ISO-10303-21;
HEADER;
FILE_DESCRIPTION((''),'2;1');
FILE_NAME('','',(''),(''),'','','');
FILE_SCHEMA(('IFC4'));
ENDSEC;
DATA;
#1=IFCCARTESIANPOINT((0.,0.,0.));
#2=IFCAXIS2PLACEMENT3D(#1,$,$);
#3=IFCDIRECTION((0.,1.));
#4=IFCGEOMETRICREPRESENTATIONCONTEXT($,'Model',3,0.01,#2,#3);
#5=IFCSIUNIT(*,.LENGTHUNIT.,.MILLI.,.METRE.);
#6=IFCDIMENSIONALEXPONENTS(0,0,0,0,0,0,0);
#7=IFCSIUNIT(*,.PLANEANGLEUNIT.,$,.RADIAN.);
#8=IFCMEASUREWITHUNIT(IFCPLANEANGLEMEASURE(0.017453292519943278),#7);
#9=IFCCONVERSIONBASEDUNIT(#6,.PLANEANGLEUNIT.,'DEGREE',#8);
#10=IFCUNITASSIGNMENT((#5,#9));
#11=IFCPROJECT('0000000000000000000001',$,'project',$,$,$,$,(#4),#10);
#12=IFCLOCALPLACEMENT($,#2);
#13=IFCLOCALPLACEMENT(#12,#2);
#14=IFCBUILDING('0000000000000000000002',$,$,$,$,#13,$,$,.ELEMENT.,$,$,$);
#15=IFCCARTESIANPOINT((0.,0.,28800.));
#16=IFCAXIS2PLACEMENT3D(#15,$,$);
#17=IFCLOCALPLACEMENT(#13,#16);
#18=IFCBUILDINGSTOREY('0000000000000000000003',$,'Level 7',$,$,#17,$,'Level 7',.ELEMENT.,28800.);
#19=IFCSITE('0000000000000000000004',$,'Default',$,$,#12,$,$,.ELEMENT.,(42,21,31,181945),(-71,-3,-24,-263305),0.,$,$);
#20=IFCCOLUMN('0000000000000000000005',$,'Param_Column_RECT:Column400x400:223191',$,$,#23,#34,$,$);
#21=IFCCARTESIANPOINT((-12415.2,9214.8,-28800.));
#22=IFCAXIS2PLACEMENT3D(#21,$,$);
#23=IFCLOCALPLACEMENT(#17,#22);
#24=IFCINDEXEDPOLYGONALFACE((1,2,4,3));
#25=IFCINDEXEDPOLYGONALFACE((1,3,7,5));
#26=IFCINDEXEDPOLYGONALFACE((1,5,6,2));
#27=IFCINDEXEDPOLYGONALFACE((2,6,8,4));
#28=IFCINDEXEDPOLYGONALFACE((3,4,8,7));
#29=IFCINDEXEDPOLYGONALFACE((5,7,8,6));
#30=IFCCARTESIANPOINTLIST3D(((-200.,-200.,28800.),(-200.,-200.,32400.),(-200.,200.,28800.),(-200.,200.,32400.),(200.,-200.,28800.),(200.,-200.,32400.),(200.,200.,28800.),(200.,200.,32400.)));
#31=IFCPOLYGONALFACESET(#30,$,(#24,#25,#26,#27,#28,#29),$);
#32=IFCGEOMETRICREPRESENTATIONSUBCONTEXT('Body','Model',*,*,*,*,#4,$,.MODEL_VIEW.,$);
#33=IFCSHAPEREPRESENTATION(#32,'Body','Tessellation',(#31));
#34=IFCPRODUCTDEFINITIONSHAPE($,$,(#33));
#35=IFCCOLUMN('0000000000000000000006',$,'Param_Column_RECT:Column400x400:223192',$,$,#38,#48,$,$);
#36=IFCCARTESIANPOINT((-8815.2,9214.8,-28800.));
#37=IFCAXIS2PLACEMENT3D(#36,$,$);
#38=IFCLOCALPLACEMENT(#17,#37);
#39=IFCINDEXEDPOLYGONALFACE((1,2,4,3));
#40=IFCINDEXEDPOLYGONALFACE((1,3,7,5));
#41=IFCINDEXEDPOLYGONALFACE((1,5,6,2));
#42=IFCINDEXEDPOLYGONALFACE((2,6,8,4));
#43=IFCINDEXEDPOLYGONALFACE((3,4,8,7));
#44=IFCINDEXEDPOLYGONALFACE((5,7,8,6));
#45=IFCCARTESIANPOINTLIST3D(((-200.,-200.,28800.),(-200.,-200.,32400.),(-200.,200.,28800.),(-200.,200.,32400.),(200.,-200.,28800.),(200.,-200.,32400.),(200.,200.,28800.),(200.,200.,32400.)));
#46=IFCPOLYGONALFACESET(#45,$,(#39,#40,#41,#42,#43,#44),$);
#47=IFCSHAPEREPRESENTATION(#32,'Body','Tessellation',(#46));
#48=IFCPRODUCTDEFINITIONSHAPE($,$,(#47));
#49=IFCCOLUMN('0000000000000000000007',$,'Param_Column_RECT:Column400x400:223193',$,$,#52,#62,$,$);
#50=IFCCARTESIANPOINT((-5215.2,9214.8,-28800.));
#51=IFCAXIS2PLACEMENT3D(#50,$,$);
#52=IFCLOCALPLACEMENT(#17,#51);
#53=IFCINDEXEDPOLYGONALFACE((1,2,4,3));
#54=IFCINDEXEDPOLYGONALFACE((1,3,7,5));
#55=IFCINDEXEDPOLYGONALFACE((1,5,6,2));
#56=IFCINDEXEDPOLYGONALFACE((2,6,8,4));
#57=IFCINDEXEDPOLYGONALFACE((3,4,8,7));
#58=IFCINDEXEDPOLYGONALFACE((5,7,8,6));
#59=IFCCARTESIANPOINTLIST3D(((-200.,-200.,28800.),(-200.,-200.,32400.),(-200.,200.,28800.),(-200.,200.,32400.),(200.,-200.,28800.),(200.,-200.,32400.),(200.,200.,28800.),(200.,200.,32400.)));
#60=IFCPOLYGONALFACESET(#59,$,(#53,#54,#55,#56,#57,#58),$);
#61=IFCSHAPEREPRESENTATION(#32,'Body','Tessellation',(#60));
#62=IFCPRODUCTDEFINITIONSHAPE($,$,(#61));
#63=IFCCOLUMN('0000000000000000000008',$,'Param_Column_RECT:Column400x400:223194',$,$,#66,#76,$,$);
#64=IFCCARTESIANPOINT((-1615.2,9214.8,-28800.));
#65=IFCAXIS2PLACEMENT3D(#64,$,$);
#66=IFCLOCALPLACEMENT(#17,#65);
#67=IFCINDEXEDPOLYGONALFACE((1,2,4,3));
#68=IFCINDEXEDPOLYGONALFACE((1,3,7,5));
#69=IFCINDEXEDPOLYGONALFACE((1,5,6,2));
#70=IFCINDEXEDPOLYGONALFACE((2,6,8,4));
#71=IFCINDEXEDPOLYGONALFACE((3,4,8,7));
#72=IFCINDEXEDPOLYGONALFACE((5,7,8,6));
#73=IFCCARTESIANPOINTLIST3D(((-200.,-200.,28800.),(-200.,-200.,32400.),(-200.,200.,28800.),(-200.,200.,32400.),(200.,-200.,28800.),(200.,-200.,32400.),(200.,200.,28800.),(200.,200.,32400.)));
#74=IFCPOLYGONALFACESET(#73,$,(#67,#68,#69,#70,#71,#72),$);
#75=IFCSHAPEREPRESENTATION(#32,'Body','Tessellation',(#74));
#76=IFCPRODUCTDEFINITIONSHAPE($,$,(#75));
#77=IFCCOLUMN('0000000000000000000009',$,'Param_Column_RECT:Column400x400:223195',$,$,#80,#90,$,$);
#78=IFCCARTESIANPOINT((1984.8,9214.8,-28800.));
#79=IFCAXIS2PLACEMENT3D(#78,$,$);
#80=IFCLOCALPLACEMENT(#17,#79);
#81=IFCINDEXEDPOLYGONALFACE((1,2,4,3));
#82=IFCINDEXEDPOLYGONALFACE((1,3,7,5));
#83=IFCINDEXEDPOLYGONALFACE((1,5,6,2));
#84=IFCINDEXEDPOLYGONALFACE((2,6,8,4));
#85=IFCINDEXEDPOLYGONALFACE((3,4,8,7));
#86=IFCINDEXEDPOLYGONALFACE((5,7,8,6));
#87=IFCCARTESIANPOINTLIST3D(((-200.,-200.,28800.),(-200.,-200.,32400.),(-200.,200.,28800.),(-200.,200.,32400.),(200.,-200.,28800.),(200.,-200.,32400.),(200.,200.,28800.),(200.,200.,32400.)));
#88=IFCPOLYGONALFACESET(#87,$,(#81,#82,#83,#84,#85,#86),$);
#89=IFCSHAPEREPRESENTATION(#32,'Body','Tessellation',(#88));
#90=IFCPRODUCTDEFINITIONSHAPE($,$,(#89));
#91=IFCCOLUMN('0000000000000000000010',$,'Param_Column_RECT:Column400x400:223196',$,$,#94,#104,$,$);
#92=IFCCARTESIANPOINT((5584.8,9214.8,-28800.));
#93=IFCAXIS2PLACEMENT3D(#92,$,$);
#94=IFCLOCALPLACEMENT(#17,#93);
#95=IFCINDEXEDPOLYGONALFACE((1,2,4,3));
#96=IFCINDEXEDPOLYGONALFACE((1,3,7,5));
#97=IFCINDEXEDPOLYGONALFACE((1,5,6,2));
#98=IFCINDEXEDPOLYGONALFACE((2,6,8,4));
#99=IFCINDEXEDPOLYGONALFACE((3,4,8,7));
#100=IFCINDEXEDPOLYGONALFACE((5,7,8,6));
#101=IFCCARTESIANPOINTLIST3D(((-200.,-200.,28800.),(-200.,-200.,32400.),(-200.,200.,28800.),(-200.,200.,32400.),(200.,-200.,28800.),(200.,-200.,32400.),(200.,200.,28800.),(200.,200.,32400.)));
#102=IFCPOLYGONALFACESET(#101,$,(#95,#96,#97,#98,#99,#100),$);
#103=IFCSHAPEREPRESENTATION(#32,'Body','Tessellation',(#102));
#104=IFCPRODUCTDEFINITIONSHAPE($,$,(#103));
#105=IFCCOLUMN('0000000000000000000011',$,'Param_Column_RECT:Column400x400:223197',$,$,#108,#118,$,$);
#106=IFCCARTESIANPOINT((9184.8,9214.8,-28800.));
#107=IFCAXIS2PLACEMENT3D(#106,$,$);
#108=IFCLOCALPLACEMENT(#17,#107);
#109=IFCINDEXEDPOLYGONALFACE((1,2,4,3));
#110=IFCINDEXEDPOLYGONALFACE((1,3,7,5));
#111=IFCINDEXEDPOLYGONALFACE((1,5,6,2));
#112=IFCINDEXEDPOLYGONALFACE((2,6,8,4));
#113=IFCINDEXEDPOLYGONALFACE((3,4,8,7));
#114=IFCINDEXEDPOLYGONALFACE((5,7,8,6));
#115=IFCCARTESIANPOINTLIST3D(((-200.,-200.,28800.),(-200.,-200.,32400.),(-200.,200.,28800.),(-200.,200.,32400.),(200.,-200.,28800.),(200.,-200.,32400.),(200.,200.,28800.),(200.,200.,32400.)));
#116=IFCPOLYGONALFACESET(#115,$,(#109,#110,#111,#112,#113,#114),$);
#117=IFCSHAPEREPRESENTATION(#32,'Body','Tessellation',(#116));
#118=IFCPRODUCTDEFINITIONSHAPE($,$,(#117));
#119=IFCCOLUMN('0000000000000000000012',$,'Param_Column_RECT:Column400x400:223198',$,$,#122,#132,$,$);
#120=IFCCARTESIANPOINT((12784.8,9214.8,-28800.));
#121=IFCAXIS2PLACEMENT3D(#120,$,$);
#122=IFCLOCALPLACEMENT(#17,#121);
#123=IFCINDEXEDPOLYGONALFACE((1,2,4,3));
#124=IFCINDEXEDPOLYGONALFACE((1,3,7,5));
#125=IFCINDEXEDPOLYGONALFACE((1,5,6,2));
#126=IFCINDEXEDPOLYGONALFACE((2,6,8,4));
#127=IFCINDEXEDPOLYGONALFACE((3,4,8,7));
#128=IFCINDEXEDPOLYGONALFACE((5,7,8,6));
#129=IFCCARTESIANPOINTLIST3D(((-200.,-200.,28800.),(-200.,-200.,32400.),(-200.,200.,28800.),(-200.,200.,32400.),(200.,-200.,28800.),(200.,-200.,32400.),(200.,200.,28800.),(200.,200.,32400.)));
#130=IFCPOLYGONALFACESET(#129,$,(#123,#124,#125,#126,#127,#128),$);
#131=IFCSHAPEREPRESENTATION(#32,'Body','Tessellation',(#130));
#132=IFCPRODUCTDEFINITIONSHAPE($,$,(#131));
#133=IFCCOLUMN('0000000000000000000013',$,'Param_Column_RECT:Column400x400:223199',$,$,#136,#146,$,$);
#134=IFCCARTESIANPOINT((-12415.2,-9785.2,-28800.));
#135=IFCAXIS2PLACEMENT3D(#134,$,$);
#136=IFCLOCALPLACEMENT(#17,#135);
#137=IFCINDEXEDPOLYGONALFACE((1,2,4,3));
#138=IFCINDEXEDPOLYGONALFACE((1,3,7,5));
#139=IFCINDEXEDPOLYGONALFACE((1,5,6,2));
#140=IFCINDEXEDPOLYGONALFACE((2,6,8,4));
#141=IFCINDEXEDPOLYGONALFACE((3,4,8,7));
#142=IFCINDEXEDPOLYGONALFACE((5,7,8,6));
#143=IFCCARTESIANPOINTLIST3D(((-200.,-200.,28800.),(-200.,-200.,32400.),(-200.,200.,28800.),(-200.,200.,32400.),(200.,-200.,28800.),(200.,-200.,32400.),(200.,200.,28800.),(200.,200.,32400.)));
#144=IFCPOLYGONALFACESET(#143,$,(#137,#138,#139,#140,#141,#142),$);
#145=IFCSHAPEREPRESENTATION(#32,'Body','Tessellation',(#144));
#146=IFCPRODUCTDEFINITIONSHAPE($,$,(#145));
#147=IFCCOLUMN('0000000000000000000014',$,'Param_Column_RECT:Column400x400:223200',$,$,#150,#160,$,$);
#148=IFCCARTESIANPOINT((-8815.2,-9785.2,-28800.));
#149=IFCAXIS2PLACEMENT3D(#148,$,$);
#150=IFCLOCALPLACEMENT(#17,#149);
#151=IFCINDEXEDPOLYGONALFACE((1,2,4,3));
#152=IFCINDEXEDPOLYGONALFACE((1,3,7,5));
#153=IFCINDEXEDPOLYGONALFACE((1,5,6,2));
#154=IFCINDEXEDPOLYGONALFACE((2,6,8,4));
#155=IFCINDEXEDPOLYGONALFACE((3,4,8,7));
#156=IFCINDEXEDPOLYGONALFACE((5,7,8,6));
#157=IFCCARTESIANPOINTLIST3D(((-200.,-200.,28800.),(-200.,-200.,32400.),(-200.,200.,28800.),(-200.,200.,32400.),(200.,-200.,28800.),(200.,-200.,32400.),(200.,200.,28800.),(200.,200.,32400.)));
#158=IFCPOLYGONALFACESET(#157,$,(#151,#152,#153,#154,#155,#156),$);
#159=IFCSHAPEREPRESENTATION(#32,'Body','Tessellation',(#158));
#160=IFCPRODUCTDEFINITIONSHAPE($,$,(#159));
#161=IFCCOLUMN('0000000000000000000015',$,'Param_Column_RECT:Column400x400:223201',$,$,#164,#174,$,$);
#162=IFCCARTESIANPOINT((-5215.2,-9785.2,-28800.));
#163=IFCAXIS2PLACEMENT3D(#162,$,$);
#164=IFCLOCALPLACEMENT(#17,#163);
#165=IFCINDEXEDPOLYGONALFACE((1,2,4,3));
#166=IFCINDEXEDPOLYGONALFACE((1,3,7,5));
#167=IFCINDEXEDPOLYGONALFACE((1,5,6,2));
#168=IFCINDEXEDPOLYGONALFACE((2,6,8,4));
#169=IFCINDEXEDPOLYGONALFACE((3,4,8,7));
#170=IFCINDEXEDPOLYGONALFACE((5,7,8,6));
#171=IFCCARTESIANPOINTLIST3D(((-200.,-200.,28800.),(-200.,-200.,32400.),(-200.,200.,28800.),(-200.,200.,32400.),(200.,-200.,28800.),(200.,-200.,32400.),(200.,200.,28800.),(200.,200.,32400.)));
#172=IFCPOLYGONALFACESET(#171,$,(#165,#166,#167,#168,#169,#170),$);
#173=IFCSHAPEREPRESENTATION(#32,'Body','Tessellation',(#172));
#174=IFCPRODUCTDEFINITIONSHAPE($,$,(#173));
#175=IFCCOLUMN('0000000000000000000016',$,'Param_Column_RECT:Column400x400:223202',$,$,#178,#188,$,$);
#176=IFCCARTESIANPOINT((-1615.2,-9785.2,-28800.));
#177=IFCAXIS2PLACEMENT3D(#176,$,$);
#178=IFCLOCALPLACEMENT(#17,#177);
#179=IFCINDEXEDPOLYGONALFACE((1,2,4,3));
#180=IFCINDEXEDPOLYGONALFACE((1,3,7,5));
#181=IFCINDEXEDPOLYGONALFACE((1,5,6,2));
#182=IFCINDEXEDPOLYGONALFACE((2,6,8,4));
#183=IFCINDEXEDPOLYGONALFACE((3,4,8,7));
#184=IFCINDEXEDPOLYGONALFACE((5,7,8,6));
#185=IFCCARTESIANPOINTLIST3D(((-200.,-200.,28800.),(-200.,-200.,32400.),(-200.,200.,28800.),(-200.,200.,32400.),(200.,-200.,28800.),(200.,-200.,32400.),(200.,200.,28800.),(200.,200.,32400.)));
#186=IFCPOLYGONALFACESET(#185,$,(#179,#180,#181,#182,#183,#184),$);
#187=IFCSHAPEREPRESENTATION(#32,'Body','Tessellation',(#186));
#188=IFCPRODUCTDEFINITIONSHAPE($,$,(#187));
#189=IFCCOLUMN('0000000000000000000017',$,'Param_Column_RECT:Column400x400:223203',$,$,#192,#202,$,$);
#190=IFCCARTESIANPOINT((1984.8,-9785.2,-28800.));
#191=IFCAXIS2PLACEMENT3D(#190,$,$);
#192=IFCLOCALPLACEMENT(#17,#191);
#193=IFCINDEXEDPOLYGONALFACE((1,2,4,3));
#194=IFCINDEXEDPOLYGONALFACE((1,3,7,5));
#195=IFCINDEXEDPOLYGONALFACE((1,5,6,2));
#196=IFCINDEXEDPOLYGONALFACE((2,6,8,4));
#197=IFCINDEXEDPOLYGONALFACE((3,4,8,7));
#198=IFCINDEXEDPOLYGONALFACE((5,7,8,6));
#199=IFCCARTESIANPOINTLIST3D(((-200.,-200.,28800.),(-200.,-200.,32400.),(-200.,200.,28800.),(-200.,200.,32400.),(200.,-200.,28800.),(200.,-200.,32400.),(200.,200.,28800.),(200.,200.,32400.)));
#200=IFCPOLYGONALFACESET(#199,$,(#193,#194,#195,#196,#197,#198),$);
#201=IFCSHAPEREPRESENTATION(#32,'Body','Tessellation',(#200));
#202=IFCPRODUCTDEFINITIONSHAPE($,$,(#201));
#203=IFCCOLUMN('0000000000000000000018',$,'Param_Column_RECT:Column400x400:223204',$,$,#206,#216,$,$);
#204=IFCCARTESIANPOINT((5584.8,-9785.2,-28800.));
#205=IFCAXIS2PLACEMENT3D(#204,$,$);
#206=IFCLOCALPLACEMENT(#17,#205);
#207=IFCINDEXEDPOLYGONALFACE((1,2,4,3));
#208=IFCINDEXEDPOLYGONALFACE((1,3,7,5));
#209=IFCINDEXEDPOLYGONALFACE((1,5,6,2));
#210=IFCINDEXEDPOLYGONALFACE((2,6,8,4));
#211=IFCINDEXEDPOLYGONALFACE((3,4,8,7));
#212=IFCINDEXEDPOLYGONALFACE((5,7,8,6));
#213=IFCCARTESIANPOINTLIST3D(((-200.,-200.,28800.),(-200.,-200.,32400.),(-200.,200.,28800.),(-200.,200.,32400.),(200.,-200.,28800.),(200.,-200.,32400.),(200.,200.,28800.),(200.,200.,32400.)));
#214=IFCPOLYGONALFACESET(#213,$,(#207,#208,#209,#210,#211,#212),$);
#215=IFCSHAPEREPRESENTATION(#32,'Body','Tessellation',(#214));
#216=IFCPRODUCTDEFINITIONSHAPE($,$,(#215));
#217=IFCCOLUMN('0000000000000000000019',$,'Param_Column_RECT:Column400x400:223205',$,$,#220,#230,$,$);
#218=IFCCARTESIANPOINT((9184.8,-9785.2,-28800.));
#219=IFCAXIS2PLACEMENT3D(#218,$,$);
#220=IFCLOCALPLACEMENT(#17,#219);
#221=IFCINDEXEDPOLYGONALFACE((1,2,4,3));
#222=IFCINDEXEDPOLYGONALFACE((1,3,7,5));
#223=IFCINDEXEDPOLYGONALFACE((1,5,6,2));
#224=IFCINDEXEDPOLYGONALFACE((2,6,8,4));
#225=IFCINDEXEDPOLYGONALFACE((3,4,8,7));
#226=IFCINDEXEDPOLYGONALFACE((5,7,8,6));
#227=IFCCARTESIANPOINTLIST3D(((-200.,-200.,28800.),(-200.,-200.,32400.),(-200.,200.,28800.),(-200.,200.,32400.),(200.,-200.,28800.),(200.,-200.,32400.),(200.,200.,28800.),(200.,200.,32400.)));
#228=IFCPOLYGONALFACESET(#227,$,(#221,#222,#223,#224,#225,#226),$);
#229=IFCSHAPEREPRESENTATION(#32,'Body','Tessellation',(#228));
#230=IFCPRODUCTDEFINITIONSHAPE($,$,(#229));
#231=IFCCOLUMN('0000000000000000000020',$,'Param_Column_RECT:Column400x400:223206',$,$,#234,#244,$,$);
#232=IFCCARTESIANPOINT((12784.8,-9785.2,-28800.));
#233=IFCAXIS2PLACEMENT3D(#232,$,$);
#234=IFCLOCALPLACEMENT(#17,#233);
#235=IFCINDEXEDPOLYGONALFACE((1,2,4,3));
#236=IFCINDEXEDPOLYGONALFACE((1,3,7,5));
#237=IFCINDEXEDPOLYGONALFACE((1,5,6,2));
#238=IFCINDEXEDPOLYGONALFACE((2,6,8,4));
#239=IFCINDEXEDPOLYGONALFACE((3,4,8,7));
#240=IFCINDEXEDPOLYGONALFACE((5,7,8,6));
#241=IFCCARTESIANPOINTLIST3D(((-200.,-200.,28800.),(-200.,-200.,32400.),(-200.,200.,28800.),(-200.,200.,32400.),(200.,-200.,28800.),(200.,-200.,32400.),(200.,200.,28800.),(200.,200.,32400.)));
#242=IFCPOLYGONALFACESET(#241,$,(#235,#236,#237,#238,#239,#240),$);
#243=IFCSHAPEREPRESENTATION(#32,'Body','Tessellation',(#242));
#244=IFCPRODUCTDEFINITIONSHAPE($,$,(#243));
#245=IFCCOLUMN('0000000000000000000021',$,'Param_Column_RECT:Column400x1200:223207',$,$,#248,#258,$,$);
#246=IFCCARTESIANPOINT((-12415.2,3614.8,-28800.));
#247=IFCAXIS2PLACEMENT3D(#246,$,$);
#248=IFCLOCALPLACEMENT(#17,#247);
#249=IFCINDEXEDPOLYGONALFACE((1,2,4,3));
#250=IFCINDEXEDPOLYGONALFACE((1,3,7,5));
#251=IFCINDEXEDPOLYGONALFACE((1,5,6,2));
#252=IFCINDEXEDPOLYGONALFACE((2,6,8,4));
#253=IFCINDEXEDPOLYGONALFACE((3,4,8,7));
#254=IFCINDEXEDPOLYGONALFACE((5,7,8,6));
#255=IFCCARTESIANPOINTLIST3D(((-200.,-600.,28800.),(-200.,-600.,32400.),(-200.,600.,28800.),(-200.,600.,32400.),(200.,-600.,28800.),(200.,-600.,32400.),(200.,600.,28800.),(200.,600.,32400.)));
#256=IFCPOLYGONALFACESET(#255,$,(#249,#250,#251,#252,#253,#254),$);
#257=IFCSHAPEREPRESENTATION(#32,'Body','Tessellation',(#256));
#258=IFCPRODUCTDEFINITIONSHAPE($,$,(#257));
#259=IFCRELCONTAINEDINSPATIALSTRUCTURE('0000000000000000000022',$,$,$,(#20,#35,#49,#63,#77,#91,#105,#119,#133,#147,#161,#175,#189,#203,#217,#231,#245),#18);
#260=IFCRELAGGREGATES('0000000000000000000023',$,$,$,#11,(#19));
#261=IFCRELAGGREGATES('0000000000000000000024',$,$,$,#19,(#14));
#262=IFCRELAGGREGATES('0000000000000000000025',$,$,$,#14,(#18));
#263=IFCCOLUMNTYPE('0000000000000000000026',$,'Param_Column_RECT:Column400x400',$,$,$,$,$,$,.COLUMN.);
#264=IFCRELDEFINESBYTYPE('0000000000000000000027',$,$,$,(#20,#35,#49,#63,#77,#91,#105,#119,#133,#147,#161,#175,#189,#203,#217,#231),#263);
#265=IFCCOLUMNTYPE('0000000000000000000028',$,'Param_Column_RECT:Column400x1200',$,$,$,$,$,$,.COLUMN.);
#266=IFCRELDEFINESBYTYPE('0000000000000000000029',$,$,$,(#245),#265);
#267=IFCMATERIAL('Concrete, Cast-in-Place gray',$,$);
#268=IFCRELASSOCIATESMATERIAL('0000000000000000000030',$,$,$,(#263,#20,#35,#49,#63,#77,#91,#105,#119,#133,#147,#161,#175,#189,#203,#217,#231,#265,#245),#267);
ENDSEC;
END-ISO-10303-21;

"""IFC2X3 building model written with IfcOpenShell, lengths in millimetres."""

from ifc_helpers import new_model, entity, si_unit, converted_unit, direction, frame, origin, origin_2d_with_axis, place, context, subcontext, project, spatial, rectangle, extrude, source, transform, mapped, material, type_object, type_shapes, element, save


model = new_model("IFC2X3")

# Units and contexts
model_context = context("Model", 3, precision=0.01, world=origin(), true_north=direction((0.0, 1.0)))
body_context = subcontext(model_context, "Body", "Model", "MODEL_VIEW")
ifc_project = project(units=[si_unit("LENGTHUNIT", "METRE", prefix="MILLI"), converted_unit("PLANEANGLEUNIT", "DEGREE", entity("IfcPlaneAngleMeasure", 0.017453292519943278), si_unit("PLANEANGLEUNIT", "RADIAN"), dimensions=[0, 0, 0, 0, 0, 0, 0])], contexts=[model_context])

# Site, building, storey
site_placement = place(None, origin())
site = spatial("IfcSite", under=ifc_project, at=site_placement, Name="Default", CompositionType="ELEMENT", RefLatitude=(42, 21, 31, 181945), RefLongitude=(-71, -3, -24, -263305), RefElevation=0.0)
building_placement = place(site_placement, origin())
building = spatial("IfcBuilding", under=site, at=building_placement, CompositionType="ELEMENT")
storey_placement = place(building_placement, frame((0.0, 0.0, 28800.0)))
storey = spatial("IfcBuildingStorey", under=building, at=storey_placement, Name="Level 7", LongName="Level 7", CompositionType="ELEMENT", Elevation=28800.0)

# Columns
ifc_material_1 = material(Name="Concrete, Cast-in-Place gray")
column_type_1 = type_object("IfcColumnType", Name="Param_Column_RECT:Column400x400", PredefinedType="COLUMN", material=ifc_material_1)
shared_shape_1 = source(origin(), body_context, "Body", "SweptSolid", [
    extrude(rectangle(XDim=400.0, YDim=400.0, at=origin_2d_with_axis()), frame((0.0, 0.0, 28800.0), z_axis=(0.0, 0.0, 1.0), x_axis=(-1.0, 0.0, 0.0)), (0.0, 0.0, 1.0), 3600.0),
])
type_shapes(column_type_1, [shared_shape_1])
for number, where, name in (
    (1, (-12415.2, 9214.8, -28800.0), "Param_Column_RECT:Column400x400:223191"),
    (2, (-8815.2, 9214.8, -28800.0), "Param_Column_RECT:Column400x400:223192"),
    (3, (-5215.2, 9214.8, -28800.0), "Param_Column_RECT:Column400x400:223193"),
    (4, (-1615.2, 9214.8, -28800.0), "Param_Column_RECT:Column400x400:223194"),
    (5, (1984.8, 9214.8, -28800.0), "Param_Column_RECT:Column400x400:223195"),
    (6, (5584.8, 9214.8, -28800.0), "Param_Column_RECT:Column400x400:223196"),
    (7, (9184.8, 9214.8, -28800.0), "Param_Column_RECT:Column400x400:223197"),
    (8, (12784.8, 9214.8, -28800.0), "Param_Column_RECT:Column400x400:223198"),
    (9, (-12415.2, -9785.2, -28800.0), "Param_Column_RECT:Column400x400:223199"),
    (10, (-8815.2, -9785.2, -28800.0), "Param_Column_RECT:Column400x400:223200"),
    (11, (-5215.2, -9785.2, -28800.0), "Param_Column_RECT:Column400x400:223201"),
    (12, (-1615.2, -9785.2, -28800.0), "Param_Column_RECT:Column400x400:223202"),
    (13, (1984.8, -9785.2, -28800.0), "Param_Column_RECT:Column400x400:223203"),
    (14, (5584.8, -9785.2, -28800.0), "Param_Column_RECT:Column400x400:223204"),
    (15, (9184.8, -9785.2, -28800.0), "Param_Column_RECT:Column400x400:223205"),
    (16, (12784.8, -9785.2, -28800.0), "Param_Column_RECT:Column400x400:223206"),
):
    element("IfcColumn", number, at=place(storey_placement, frame(where)), inside=storey, type_object=column_type_1, material=ifc_material_1, Name=name, context=body_context, shape_type="MappedRepresentation", body=[
        mapped(shared_shape_1, transform((0.0, 0.0, 0.0), scale=1.0)),
    ])
column_type_2 = type_object("IfcColumnType", Name="Param_Column_RECT:Column400x1200", PredefinedType="COLUMN", material=ifc_material_1)
shared_shape_2 = source(origin(), body_context, "Body", "SweptSolid", [
    extrude(rectangle(XDim=400.0, YDim=1200.0, at=origin_2d_with_axis()), frame((0.0, 0.0, 28800.0), z_axis=(0.0, 0.0, 1.0), x_axis=(-1.0, 0.0, 0.0)), (0.0, 0.0, 1.0), 3600.0),
])
type_shapes(column_type_2, [shared_shape_2])
for number, where, name in (
    (17, (-12415.2, 3614.8, -28800.0), "Param_Column_RECT:Column400x1200:223207"),
):
    element("IfcColumn", number, at=place(storey_placement, frame(where)), inside=storey, type_object=column_type_2, material=ifc_material_1, Name=name, context=body_context, shape_type="MappedRepresentation", body=[
        mapped(shared_shape_2, transform((0.0, 0.0, 0.0), scale=1.0)),
    ])

save(model, "model.ifc")
